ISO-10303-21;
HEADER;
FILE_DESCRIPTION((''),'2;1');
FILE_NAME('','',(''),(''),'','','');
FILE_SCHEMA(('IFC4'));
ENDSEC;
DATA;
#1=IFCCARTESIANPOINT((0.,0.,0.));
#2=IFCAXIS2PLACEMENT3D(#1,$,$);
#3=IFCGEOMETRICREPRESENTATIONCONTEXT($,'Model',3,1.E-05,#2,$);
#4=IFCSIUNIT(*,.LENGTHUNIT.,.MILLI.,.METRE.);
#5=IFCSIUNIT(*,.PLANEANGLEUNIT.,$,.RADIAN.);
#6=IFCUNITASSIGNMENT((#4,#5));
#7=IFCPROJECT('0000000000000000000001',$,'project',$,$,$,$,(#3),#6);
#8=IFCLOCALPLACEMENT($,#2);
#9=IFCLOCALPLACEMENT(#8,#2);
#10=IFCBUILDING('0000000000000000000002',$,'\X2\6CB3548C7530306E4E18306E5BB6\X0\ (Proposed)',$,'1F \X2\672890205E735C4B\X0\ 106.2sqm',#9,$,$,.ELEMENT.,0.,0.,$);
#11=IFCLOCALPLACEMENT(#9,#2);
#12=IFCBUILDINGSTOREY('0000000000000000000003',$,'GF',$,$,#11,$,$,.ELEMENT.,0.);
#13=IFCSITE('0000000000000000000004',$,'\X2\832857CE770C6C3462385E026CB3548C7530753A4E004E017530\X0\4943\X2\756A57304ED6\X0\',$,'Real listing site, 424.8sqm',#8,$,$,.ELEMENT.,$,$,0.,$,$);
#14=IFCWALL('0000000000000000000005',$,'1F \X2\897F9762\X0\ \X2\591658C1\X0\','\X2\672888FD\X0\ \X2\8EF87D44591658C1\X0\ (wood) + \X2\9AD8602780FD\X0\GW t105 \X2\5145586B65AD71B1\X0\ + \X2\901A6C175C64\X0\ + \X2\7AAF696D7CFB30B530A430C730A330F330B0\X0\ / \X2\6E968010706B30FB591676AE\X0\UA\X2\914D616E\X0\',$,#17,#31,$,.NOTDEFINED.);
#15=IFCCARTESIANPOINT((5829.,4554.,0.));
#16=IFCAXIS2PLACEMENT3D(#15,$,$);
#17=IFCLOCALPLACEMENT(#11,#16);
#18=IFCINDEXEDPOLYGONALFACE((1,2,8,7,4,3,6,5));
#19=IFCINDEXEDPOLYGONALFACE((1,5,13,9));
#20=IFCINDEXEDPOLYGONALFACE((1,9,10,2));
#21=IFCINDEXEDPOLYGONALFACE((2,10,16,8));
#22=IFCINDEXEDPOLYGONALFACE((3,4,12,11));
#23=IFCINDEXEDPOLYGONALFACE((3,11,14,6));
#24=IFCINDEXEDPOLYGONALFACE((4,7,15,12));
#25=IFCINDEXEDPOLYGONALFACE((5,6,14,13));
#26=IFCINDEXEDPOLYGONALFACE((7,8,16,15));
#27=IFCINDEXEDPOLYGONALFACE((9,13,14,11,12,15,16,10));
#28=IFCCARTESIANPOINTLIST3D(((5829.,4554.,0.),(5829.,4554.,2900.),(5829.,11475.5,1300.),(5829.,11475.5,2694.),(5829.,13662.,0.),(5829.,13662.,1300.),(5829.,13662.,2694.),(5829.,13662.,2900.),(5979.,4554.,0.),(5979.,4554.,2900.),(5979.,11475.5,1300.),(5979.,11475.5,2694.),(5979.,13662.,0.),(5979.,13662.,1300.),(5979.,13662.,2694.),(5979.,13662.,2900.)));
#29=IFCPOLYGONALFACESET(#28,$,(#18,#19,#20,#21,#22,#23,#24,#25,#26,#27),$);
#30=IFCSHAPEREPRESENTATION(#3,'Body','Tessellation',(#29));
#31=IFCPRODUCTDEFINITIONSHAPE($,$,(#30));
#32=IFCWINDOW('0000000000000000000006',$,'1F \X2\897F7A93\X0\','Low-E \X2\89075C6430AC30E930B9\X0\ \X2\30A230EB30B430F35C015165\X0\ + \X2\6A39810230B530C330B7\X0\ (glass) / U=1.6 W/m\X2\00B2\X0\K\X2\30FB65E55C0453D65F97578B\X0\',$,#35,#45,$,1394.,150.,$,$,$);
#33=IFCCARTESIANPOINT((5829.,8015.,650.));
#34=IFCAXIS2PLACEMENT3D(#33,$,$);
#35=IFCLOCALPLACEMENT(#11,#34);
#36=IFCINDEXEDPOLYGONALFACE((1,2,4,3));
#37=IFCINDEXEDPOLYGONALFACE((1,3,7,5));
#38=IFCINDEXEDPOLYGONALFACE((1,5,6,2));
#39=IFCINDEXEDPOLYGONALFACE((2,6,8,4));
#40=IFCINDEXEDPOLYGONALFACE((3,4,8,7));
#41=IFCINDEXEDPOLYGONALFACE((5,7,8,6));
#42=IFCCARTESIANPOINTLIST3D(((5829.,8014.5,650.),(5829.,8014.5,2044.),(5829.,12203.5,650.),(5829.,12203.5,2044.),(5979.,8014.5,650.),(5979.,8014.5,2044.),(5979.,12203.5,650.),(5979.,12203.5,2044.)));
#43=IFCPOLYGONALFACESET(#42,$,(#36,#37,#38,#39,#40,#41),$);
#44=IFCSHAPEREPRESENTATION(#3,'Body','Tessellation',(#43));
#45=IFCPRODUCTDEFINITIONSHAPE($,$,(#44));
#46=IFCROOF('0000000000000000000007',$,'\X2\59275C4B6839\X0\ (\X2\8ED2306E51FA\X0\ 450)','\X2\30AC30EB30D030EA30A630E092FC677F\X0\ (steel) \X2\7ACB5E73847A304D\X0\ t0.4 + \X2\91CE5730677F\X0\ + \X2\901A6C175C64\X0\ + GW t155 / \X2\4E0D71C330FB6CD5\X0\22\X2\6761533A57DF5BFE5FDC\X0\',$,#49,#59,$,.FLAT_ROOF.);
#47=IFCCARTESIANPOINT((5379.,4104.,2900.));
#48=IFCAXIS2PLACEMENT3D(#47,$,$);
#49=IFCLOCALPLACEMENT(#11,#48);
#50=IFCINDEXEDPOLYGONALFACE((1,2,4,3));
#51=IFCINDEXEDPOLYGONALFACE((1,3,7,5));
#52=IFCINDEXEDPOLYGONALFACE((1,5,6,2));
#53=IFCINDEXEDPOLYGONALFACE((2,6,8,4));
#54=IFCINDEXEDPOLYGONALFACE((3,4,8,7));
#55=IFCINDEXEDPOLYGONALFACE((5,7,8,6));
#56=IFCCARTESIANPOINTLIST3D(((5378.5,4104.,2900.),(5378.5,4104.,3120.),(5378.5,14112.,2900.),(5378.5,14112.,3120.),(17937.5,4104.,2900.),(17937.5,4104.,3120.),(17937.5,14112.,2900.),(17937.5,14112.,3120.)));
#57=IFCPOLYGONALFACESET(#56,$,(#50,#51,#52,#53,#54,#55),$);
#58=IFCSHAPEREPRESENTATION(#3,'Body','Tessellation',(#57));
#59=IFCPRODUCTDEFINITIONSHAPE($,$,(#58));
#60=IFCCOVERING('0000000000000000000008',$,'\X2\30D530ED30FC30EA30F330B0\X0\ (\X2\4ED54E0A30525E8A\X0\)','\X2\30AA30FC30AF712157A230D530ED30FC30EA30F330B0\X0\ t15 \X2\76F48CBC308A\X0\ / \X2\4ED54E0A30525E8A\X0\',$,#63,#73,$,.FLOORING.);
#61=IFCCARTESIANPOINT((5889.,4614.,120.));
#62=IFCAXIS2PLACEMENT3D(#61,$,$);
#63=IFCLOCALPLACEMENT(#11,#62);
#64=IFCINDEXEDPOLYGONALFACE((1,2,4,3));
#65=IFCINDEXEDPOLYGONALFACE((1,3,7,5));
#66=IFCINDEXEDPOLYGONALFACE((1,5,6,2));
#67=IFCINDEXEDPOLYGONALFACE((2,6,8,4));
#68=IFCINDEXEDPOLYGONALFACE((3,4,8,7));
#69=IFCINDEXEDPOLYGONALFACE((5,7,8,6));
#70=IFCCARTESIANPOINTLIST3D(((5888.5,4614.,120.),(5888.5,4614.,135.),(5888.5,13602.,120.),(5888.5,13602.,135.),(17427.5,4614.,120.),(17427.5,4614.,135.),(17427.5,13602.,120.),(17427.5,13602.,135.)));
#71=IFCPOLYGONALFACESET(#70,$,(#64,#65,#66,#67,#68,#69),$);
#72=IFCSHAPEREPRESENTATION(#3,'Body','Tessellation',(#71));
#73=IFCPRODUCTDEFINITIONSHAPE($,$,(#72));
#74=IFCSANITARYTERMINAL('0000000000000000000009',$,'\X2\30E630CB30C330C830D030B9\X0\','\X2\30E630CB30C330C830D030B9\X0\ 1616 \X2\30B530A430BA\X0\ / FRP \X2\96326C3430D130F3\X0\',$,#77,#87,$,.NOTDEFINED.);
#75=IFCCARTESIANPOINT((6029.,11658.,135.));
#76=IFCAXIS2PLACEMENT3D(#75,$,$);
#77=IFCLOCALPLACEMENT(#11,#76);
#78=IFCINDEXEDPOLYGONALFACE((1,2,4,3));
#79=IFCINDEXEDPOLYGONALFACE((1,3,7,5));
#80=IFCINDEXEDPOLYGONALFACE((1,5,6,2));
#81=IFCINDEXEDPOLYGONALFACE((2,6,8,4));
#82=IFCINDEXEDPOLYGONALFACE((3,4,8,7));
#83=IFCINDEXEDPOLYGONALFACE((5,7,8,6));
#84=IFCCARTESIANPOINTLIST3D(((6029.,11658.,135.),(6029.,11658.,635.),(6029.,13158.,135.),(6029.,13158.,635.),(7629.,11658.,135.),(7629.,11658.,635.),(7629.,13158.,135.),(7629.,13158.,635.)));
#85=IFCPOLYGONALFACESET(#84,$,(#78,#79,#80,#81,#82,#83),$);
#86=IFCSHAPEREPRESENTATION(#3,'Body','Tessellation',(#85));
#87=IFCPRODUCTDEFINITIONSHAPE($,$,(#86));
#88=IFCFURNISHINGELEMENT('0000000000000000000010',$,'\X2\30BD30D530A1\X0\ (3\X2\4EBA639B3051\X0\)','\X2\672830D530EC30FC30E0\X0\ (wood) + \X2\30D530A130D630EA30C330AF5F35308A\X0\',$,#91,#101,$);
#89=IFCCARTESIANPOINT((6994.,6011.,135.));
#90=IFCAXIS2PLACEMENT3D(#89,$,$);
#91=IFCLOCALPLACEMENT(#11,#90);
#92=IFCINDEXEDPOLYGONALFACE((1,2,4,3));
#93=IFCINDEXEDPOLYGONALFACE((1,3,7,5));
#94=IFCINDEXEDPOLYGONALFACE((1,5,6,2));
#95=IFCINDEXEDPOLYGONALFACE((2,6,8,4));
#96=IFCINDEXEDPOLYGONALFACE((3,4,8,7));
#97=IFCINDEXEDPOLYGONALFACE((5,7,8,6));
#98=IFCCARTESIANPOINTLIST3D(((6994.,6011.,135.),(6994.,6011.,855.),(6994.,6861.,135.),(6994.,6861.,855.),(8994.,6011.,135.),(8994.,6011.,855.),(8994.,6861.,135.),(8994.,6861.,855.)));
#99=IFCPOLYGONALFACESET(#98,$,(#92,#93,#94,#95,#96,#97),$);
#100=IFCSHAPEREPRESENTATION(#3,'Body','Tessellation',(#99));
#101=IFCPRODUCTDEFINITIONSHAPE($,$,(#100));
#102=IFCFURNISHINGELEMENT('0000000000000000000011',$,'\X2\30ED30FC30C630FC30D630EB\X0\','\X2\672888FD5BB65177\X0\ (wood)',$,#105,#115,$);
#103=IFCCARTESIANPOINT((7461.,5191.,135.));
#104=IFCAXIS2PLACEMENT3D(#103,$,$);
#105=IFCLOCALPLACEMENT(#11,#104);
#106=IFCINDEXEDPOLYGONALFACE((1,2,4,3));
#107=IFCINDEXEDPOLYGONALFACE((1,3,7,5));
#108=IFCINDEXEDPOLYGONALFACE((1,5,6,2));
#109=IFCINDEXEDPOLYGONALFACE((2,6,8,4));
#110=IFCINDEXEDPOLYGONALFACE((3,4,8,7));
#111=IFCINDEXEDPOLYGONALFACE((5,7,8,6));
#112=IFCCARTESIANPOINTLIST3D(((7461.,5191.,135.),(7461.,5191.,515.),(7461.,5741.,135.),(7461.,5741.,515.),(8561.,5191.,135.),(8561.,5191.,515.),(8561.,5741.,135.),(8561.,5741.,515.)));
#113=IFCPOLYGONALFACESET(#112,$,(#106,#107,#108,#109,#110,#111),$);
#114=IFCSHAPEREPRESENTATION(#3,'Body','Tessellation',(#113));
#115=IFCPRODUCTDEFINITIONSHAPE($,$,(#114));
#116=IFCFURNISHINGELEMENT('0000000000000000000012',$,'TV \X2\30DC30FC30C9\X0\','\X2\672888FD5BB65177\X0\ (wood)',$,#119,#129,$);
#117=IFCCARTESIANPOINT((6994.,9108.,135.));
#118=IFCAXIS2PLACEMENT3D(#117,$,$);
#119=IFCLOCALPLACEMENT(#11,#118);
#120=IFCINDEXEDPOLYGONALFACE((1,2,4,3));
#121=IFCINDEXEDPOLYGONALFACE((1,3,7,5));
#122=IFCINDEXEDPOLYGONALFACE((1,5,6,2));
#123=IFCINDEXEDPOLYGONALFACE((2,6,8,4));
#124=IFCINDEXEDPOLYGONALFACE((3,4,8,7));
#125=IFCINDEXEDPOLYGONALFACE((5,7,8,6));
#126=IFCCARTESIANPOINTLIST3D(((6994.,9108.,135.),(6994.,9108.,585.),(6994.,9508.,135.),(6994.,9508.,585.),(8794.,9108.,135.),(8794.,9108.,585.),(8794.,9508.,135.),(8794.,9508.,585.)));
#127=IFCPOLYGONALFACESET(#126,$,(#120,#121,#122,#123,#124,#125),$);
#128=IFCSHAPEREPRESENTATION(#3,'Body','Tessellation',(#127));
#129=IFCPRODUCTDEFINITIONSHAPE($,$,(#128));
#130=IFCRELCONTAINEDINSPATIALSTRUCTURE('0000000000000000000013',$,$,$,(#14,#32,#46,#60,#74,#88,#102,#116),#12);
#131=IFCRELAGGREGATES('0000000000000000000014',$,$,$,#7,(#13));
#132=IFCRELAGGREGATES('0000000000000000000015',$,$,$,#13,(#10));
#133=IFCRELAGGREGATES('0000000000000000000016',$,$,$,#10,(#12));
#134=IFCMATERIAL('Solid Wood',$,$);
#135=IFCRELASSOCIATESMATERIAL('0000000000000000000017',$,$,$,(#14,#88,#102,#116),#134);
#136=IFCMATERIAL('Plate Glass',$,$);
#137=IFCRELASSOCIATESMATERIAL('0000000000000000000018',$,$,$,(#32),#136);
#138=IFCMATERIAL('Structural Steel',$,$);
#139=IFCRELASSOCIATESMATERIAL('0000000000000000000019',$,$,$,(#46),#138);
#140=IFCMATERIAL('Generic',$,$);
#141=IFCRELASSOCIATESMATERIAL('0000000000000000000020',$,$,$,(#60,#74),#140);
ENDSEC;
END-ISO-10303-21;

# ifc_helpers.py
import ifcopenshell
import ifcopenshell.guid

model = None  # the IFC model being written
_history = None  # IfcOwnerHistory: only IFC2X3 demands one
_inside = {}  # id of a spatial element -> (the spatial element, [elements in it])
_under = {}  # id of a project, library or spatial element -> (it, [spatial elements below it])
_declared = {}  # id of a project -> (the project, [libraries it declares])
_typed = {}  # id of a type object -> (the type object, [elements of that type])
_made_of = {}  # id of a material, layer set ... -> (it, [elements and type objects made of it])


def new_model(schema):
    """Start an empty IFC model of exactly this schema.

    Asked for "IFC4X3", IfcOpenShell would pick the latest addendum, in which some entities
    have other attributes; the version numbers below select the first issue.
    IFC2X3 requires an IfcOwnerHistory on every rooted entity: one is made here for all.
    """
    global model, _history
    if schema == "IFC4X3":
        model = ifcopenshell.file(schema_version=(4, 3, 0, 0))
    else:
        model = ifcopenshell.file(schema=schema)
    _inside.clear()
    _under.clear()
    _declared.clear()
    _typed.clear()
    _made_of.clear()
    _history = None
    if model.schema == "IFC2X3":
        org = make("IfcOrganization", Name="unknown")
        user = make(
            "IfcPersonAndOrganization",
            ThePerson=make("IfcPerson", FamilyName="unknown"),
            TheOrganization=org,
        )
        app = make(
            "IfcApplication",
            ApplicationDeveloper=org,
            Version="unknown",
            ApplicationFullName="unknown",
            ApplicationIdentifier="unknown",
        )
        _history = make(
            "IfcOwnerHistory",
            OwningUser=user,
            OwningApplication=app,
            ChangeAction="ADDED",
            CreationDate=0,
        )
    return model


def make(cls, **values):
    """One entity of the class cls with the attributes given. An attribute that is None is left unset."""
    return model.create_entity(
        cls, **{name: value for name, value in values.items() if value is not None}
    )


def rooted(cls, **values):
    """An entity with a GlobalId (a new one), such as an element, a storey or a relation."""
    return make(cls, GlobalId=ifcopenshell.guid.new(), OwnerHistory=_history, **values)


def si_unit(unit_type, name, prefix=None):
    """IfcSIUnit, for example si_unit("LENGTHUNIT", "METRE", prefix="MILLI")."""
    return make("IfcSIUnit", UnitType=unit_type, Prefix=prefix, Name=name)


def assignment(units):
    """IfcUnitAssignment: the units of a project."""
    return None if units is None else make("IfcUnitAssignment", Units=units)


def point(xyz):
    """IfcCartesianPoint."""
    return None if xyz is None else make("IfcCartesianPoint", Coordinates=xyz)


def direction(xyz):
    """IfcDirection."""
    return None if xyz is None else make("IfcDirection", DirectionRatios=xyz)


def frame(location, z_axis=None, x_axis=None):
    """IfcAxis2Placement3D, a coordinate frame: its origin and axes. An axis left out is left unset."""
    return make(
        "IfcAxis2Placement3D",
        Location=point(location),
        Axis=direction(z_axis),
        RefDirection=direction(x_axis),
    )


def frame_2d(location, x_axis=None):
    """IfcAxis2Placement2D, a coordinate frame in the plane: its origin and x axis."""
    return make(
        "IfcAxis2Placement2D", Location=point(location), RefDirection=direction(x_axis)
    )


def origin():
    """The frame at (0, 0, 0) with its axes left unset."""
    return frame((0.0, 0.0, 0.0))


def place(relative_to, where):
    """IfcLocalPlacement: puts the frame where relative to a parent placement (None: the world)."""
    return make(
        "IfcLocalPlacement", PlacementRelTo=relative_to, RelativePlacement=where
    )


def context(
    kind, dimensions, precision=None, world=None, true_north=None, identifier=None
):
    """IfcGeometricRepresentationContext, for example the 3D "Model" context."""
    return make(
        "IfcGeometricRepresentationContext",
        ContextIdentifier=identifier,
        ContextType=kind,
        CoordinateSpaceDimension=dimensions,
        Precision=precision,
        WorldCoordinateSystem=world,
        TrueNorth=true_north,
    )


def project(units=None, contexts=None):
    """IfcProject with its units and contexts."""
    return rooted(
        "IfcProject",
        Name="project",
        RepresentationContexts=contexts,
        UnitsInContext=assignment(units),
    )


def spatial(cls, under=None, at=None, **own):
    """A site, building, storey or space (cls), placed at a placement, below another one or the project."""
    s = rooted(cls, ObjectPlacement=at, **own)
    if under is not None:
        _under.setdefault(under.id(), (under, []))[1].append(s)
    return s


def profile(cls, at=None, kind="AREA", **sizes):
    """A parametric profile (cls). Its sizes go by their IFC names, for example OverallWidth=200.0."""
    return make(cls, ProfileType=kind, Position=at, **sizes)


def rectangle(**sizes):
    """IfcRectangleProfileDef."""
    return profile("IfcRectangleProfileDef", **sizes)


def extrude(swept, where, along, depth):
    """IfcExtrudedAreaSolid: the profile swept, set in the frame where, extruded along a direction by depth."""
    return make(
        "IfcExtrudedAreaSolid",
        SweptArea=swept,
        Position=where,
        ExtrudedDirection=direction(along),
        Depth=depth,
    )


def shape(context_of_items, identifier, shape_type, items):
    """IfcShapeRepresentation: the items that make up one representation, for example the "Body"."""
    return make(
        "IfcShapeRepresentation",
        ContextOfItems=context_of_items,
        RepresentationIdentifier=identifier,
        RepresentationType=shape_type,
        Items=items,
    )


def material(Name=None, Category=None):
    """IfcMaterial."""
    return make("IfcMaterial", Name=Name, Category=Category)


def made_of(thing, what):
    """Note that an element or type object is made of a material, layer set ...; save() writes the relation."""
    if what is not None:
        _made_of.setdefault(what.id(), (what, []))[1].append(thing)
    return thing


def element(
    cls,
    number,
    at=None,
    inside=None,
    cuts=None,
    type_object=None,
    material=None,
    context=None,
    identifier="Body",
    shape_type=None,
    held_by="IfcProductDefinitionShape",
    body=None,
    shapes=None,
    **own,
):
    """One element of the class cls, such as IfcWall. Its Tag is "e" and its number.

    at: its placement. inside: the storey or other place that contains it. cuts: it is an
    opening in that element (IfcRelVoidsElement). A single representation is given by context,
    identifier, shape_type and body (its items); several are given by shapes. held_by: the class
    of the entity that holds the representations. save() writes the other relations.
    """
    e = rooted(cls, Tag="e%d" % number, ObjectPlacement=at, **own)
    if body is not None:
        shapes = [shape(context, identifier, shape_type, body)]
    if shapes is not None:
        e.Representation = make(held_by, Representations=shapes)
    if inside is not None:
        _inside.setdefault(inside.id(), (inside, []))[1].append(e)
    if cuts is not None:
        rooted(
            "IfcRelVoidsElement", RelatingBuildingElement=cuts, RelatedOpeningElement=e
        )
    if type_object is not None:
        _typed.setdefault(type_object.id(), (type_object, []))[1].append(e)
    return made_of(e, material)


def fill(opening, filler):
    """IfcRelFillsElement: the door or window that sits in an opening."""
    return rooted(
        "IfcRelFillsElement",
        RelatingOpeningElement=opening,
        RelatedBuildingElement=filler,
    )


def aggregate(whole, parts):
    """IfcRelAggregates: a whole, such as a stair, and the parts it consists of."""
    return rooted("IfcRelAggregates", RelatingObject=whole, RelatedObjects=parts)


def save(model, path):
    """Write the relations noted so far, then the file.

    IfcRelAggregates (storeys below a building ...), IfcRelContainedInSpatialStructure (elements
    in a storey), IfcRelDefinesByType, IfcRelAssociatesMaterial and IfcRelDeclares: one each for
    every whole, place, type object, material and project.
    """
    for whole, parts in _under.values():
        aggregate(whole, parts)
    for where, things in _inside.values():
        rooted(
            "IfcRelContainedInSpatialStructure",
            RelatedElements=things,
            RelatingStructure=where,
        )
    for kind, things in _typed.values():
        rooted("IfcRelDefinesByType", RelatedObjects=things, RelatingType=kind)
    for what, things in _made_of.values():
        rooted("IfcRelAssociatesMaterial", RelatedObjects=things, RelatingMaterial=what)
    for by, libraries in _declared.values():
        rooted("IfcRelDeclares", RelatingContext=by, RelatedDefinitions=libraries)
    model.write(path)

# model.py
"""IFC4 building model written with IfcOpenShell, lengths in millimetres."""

from ifc_helpers import new_model, si_unit, frame, frame_2d, origin, place, context, project, spatial, rectangle, extrude, material, element, fill, save


model = new_model("IFC4")

# Units and contexts
model_context = context("Model", 3, precision=1e-05, world=origin())
ifc_project = project(units=[si_unit("LENGTHUNIT", "METRE", prefix="MILLI"), si_unit("PLANEANGLEUNIT", "RADIAN")], contexts=[model_context])

# Site, building, storey
site_placement = place(None, origin())
site = spatial("IfcSite", under=ifc_project, at=site_placement, Name="茨城県水戸市河和田町一丁田4943番地他", ObjectType="Real listing site, 424.8sqm", CompositionType="ELEMENT", RefElevation=0.0)
building_placement = place(site_placement, origin())
building = spatial("IfcBuilding", under=site, at=building_placement, Name="河和田の丘の家 (Proposed)", ObjectType="1F 木造平屋 106.2sqm", CompositionType="ELEMENT", ElevationOfRefHeight=0.0, ElevationOfTerrain=0.0)
storey_placement = place(building_placement, origin())
storey = spatial("IfcBuildingStorey", under=building, at=storey_placement, Name="GF", CompositionType="ELEMENT", Elevation=0.0)

# Shared definitions
ifc_material_1 = material(Name="Solid Wood")

# Shared definitions
ifc_material_2 = material(Name="Plate Glass")

# Wall, opening, window
wall_1_placement = place(storey_placement, frame((5829.0, 4554.0, 0.0)))
wall_1 = element("IfcWall", 1, at=wall_1_placement, inside=storey, material=ifc_material_1, Name="1F 西面 外壁", Description="木製 軸組外壁 (wood) + 高性能GW t105 充填断熱 + 通気層 + 窯業系サイディング / 準耐火・外皮UA配慮", PredefinedType="NOTDEFINED", context=model_context, shape_type="SweptSolid", body=[
    extrude(rectangle(XDim=150.0, YDim=9108.0, at=frame_2d((75.0, 4554.0))), frame((5829.0, 4554.0, 0.0)), (0.0, 0.0, 1.0), 2900.0),
])
opening_1_placement = place(storey_placement, frame((5829.0, 8015.0, 650.0)))
opening_1 = element("IfcOpeningElement", 2, at=opening_1_placement, cuts=wall_1, PredefinedType="NOTDEFINED", context=model_context, shape_type="SweptSolid", body=[
    extrude(rectangle(XDim=150.0, YDim=4189.0, at=frame_2d((75.0, 2094.0))), frame((5829.0, 8015.0, 650.0)), (0.0, 0.0, 1.0), 1394.0),
])
window_1_placement = place(storey_placement, frame((5829.0, 8015.0, 650.0)))
window_1 = element("IfcWindow", 3, at=window_1_placement, inside=storey, material=ifc_material_2, Name="1F 西窓", Description="Low-E 複層ガラス アルゴン封入 + 樹脂サッシ (glass) / U=1.6 W/m²K・日射取得型", OverallHeight=1394.0, OverallWidth=150.0, context=model_context, shape_type="SweptSolid", body=[
    extrude(rectangle(XDim=150.0, YDim=4189.0, at=frame_2d((75.0, 2094.0))), frame((5829.0, 8015.0, 650.0)), (0.0, 0.0, 1.0), 1394.0),
])
fill(opening_1, window_1)

# Roof
ifc_material_3 = material(Name="Structural Steel")
roof_placement = place(storey_placement, frame((5379.0, 4104.0, 2900.0)))
element("IfcRoof", 4, at=roof_placement, inside=storey, material=ifc_material_3, Name="大屋根 (軒の出 450)", Description="ガルバリウム鋼板 (steel) 立平葺き t0.4 + 野地板 + 通気層 + GW t155 / 不燃・法22条区域対応", PredefinedType="FLAT_ROOF", context=model_context, shape_type="SweptSolid", body=[
    extrude(rectangle(XDim=12559.0, YDim=10008.0, at=frame_2d((6279.0, 5004.0))), frame((5379.0, 4104.0, 2900.0)), (0.0, 0.0, 1.0), 220.0),
])

# Covering
ifc_material_4 = material(Name="Generic")
covering_placement = place(storey_placement, frame((5889.0, 4614.0, 120.0)))
element("IfcCovering", 5, at=covering_placement, inside=storey, material=ifc_material_4, Name="フローリング (仕上げ床)", Description="オーク無垢フローリング t15 直貼り / 仕上げ床", PredefinedType="FLOORING", context=model_context, shape_type="SweptSolid", body=[
    extrude(rectangle(XDim=11539.0, YDim=8988.0, at=frame_2d((5769.0, 4494.0))), frame((5889.0, 4614.0, 120.0)), (0.0, 0.0, 1.0), 15.0),
])

# Sanitary terminal
sanitary_terminal_placement = place(storey_placement, frame((6029.0, 11658.0, 135.0)))
element("IfcSanitaryTerminal", 6, at=sanitary_terminal_placement, inside=storey, material=ifc_material_4, Name="ユニットバス", Description="ユニットバス 1616 サイズ / FRP 防水パン", PredefinedType="NOTDEFINED", context=model_context, shape_type="SweptSolid", body=[
    extrude(rectangle(XDim=1600.0, YDim=1500.0, at=frame_2d((800.0, 750.0))), frame((6029.0, 11658.0, 135.0)), (0.0, 0.0, 1.0), 500.0),
])

# Furnishing elements
furnishing_1_placement = place(storey_placement, frame((6994.0, 6011.0, 135.0)))
element("IfcFurnishingElement", 7, at=furnishing_1_placement, inside=storey, material=ifc_material_1, Name="ソファ (3人掛け)", Description="木フレーム (wood) + ファブリック張り", context=model_context, shape_type="SweptSolid", body=[
    extrude(rectangle(XDim=2000.0, YDim=850.0, at=frame_2d((1000.0, 425.0))), frame((6994.0, 6011.0, 135.0)), (0.0, 0.0, 1.0), 720.0),
])
furnishing_2_placement = place(storey_placement, frame((7461.0, 5191.0, 135.0)))
element("IfcFurnishingElement", 8, at=furnishing_2_placement, inside=storey, material=ifc_material_1, Name="ローテーブル", Description="木製家具 (wood)", context=model_context, shape_type="SweptSolid", body=[
    extrude(rectangle(XDim=1100.0, YDim=550.0, at=frame_2d((550.0, 275.0))), frame((7461.0, 5191.0, 135.0)), (0.0, 0.0, 1.0), 380.0),
])
furnishing_3_placement = place(storey_placement, frame((6994.0, 9108.0, 135.0)))
element("IfcFurnishingElement", 9, at=furnishing_3_placement, inside=storey, material=ifc_material_1, Name="TV ボード", Description="木製家具 (wood)", context=model_context, shape_type="SweptSolid", body=[
    extrude(rectangle(XDim=1800.0, YDim=400.0, at=frame_2d((900.0, 200.0))), frame((6994.0, 9108.0, 135.0)), (0.0, 0.0, 1.0), 450.0),
])

save(model, "model.ifc")
